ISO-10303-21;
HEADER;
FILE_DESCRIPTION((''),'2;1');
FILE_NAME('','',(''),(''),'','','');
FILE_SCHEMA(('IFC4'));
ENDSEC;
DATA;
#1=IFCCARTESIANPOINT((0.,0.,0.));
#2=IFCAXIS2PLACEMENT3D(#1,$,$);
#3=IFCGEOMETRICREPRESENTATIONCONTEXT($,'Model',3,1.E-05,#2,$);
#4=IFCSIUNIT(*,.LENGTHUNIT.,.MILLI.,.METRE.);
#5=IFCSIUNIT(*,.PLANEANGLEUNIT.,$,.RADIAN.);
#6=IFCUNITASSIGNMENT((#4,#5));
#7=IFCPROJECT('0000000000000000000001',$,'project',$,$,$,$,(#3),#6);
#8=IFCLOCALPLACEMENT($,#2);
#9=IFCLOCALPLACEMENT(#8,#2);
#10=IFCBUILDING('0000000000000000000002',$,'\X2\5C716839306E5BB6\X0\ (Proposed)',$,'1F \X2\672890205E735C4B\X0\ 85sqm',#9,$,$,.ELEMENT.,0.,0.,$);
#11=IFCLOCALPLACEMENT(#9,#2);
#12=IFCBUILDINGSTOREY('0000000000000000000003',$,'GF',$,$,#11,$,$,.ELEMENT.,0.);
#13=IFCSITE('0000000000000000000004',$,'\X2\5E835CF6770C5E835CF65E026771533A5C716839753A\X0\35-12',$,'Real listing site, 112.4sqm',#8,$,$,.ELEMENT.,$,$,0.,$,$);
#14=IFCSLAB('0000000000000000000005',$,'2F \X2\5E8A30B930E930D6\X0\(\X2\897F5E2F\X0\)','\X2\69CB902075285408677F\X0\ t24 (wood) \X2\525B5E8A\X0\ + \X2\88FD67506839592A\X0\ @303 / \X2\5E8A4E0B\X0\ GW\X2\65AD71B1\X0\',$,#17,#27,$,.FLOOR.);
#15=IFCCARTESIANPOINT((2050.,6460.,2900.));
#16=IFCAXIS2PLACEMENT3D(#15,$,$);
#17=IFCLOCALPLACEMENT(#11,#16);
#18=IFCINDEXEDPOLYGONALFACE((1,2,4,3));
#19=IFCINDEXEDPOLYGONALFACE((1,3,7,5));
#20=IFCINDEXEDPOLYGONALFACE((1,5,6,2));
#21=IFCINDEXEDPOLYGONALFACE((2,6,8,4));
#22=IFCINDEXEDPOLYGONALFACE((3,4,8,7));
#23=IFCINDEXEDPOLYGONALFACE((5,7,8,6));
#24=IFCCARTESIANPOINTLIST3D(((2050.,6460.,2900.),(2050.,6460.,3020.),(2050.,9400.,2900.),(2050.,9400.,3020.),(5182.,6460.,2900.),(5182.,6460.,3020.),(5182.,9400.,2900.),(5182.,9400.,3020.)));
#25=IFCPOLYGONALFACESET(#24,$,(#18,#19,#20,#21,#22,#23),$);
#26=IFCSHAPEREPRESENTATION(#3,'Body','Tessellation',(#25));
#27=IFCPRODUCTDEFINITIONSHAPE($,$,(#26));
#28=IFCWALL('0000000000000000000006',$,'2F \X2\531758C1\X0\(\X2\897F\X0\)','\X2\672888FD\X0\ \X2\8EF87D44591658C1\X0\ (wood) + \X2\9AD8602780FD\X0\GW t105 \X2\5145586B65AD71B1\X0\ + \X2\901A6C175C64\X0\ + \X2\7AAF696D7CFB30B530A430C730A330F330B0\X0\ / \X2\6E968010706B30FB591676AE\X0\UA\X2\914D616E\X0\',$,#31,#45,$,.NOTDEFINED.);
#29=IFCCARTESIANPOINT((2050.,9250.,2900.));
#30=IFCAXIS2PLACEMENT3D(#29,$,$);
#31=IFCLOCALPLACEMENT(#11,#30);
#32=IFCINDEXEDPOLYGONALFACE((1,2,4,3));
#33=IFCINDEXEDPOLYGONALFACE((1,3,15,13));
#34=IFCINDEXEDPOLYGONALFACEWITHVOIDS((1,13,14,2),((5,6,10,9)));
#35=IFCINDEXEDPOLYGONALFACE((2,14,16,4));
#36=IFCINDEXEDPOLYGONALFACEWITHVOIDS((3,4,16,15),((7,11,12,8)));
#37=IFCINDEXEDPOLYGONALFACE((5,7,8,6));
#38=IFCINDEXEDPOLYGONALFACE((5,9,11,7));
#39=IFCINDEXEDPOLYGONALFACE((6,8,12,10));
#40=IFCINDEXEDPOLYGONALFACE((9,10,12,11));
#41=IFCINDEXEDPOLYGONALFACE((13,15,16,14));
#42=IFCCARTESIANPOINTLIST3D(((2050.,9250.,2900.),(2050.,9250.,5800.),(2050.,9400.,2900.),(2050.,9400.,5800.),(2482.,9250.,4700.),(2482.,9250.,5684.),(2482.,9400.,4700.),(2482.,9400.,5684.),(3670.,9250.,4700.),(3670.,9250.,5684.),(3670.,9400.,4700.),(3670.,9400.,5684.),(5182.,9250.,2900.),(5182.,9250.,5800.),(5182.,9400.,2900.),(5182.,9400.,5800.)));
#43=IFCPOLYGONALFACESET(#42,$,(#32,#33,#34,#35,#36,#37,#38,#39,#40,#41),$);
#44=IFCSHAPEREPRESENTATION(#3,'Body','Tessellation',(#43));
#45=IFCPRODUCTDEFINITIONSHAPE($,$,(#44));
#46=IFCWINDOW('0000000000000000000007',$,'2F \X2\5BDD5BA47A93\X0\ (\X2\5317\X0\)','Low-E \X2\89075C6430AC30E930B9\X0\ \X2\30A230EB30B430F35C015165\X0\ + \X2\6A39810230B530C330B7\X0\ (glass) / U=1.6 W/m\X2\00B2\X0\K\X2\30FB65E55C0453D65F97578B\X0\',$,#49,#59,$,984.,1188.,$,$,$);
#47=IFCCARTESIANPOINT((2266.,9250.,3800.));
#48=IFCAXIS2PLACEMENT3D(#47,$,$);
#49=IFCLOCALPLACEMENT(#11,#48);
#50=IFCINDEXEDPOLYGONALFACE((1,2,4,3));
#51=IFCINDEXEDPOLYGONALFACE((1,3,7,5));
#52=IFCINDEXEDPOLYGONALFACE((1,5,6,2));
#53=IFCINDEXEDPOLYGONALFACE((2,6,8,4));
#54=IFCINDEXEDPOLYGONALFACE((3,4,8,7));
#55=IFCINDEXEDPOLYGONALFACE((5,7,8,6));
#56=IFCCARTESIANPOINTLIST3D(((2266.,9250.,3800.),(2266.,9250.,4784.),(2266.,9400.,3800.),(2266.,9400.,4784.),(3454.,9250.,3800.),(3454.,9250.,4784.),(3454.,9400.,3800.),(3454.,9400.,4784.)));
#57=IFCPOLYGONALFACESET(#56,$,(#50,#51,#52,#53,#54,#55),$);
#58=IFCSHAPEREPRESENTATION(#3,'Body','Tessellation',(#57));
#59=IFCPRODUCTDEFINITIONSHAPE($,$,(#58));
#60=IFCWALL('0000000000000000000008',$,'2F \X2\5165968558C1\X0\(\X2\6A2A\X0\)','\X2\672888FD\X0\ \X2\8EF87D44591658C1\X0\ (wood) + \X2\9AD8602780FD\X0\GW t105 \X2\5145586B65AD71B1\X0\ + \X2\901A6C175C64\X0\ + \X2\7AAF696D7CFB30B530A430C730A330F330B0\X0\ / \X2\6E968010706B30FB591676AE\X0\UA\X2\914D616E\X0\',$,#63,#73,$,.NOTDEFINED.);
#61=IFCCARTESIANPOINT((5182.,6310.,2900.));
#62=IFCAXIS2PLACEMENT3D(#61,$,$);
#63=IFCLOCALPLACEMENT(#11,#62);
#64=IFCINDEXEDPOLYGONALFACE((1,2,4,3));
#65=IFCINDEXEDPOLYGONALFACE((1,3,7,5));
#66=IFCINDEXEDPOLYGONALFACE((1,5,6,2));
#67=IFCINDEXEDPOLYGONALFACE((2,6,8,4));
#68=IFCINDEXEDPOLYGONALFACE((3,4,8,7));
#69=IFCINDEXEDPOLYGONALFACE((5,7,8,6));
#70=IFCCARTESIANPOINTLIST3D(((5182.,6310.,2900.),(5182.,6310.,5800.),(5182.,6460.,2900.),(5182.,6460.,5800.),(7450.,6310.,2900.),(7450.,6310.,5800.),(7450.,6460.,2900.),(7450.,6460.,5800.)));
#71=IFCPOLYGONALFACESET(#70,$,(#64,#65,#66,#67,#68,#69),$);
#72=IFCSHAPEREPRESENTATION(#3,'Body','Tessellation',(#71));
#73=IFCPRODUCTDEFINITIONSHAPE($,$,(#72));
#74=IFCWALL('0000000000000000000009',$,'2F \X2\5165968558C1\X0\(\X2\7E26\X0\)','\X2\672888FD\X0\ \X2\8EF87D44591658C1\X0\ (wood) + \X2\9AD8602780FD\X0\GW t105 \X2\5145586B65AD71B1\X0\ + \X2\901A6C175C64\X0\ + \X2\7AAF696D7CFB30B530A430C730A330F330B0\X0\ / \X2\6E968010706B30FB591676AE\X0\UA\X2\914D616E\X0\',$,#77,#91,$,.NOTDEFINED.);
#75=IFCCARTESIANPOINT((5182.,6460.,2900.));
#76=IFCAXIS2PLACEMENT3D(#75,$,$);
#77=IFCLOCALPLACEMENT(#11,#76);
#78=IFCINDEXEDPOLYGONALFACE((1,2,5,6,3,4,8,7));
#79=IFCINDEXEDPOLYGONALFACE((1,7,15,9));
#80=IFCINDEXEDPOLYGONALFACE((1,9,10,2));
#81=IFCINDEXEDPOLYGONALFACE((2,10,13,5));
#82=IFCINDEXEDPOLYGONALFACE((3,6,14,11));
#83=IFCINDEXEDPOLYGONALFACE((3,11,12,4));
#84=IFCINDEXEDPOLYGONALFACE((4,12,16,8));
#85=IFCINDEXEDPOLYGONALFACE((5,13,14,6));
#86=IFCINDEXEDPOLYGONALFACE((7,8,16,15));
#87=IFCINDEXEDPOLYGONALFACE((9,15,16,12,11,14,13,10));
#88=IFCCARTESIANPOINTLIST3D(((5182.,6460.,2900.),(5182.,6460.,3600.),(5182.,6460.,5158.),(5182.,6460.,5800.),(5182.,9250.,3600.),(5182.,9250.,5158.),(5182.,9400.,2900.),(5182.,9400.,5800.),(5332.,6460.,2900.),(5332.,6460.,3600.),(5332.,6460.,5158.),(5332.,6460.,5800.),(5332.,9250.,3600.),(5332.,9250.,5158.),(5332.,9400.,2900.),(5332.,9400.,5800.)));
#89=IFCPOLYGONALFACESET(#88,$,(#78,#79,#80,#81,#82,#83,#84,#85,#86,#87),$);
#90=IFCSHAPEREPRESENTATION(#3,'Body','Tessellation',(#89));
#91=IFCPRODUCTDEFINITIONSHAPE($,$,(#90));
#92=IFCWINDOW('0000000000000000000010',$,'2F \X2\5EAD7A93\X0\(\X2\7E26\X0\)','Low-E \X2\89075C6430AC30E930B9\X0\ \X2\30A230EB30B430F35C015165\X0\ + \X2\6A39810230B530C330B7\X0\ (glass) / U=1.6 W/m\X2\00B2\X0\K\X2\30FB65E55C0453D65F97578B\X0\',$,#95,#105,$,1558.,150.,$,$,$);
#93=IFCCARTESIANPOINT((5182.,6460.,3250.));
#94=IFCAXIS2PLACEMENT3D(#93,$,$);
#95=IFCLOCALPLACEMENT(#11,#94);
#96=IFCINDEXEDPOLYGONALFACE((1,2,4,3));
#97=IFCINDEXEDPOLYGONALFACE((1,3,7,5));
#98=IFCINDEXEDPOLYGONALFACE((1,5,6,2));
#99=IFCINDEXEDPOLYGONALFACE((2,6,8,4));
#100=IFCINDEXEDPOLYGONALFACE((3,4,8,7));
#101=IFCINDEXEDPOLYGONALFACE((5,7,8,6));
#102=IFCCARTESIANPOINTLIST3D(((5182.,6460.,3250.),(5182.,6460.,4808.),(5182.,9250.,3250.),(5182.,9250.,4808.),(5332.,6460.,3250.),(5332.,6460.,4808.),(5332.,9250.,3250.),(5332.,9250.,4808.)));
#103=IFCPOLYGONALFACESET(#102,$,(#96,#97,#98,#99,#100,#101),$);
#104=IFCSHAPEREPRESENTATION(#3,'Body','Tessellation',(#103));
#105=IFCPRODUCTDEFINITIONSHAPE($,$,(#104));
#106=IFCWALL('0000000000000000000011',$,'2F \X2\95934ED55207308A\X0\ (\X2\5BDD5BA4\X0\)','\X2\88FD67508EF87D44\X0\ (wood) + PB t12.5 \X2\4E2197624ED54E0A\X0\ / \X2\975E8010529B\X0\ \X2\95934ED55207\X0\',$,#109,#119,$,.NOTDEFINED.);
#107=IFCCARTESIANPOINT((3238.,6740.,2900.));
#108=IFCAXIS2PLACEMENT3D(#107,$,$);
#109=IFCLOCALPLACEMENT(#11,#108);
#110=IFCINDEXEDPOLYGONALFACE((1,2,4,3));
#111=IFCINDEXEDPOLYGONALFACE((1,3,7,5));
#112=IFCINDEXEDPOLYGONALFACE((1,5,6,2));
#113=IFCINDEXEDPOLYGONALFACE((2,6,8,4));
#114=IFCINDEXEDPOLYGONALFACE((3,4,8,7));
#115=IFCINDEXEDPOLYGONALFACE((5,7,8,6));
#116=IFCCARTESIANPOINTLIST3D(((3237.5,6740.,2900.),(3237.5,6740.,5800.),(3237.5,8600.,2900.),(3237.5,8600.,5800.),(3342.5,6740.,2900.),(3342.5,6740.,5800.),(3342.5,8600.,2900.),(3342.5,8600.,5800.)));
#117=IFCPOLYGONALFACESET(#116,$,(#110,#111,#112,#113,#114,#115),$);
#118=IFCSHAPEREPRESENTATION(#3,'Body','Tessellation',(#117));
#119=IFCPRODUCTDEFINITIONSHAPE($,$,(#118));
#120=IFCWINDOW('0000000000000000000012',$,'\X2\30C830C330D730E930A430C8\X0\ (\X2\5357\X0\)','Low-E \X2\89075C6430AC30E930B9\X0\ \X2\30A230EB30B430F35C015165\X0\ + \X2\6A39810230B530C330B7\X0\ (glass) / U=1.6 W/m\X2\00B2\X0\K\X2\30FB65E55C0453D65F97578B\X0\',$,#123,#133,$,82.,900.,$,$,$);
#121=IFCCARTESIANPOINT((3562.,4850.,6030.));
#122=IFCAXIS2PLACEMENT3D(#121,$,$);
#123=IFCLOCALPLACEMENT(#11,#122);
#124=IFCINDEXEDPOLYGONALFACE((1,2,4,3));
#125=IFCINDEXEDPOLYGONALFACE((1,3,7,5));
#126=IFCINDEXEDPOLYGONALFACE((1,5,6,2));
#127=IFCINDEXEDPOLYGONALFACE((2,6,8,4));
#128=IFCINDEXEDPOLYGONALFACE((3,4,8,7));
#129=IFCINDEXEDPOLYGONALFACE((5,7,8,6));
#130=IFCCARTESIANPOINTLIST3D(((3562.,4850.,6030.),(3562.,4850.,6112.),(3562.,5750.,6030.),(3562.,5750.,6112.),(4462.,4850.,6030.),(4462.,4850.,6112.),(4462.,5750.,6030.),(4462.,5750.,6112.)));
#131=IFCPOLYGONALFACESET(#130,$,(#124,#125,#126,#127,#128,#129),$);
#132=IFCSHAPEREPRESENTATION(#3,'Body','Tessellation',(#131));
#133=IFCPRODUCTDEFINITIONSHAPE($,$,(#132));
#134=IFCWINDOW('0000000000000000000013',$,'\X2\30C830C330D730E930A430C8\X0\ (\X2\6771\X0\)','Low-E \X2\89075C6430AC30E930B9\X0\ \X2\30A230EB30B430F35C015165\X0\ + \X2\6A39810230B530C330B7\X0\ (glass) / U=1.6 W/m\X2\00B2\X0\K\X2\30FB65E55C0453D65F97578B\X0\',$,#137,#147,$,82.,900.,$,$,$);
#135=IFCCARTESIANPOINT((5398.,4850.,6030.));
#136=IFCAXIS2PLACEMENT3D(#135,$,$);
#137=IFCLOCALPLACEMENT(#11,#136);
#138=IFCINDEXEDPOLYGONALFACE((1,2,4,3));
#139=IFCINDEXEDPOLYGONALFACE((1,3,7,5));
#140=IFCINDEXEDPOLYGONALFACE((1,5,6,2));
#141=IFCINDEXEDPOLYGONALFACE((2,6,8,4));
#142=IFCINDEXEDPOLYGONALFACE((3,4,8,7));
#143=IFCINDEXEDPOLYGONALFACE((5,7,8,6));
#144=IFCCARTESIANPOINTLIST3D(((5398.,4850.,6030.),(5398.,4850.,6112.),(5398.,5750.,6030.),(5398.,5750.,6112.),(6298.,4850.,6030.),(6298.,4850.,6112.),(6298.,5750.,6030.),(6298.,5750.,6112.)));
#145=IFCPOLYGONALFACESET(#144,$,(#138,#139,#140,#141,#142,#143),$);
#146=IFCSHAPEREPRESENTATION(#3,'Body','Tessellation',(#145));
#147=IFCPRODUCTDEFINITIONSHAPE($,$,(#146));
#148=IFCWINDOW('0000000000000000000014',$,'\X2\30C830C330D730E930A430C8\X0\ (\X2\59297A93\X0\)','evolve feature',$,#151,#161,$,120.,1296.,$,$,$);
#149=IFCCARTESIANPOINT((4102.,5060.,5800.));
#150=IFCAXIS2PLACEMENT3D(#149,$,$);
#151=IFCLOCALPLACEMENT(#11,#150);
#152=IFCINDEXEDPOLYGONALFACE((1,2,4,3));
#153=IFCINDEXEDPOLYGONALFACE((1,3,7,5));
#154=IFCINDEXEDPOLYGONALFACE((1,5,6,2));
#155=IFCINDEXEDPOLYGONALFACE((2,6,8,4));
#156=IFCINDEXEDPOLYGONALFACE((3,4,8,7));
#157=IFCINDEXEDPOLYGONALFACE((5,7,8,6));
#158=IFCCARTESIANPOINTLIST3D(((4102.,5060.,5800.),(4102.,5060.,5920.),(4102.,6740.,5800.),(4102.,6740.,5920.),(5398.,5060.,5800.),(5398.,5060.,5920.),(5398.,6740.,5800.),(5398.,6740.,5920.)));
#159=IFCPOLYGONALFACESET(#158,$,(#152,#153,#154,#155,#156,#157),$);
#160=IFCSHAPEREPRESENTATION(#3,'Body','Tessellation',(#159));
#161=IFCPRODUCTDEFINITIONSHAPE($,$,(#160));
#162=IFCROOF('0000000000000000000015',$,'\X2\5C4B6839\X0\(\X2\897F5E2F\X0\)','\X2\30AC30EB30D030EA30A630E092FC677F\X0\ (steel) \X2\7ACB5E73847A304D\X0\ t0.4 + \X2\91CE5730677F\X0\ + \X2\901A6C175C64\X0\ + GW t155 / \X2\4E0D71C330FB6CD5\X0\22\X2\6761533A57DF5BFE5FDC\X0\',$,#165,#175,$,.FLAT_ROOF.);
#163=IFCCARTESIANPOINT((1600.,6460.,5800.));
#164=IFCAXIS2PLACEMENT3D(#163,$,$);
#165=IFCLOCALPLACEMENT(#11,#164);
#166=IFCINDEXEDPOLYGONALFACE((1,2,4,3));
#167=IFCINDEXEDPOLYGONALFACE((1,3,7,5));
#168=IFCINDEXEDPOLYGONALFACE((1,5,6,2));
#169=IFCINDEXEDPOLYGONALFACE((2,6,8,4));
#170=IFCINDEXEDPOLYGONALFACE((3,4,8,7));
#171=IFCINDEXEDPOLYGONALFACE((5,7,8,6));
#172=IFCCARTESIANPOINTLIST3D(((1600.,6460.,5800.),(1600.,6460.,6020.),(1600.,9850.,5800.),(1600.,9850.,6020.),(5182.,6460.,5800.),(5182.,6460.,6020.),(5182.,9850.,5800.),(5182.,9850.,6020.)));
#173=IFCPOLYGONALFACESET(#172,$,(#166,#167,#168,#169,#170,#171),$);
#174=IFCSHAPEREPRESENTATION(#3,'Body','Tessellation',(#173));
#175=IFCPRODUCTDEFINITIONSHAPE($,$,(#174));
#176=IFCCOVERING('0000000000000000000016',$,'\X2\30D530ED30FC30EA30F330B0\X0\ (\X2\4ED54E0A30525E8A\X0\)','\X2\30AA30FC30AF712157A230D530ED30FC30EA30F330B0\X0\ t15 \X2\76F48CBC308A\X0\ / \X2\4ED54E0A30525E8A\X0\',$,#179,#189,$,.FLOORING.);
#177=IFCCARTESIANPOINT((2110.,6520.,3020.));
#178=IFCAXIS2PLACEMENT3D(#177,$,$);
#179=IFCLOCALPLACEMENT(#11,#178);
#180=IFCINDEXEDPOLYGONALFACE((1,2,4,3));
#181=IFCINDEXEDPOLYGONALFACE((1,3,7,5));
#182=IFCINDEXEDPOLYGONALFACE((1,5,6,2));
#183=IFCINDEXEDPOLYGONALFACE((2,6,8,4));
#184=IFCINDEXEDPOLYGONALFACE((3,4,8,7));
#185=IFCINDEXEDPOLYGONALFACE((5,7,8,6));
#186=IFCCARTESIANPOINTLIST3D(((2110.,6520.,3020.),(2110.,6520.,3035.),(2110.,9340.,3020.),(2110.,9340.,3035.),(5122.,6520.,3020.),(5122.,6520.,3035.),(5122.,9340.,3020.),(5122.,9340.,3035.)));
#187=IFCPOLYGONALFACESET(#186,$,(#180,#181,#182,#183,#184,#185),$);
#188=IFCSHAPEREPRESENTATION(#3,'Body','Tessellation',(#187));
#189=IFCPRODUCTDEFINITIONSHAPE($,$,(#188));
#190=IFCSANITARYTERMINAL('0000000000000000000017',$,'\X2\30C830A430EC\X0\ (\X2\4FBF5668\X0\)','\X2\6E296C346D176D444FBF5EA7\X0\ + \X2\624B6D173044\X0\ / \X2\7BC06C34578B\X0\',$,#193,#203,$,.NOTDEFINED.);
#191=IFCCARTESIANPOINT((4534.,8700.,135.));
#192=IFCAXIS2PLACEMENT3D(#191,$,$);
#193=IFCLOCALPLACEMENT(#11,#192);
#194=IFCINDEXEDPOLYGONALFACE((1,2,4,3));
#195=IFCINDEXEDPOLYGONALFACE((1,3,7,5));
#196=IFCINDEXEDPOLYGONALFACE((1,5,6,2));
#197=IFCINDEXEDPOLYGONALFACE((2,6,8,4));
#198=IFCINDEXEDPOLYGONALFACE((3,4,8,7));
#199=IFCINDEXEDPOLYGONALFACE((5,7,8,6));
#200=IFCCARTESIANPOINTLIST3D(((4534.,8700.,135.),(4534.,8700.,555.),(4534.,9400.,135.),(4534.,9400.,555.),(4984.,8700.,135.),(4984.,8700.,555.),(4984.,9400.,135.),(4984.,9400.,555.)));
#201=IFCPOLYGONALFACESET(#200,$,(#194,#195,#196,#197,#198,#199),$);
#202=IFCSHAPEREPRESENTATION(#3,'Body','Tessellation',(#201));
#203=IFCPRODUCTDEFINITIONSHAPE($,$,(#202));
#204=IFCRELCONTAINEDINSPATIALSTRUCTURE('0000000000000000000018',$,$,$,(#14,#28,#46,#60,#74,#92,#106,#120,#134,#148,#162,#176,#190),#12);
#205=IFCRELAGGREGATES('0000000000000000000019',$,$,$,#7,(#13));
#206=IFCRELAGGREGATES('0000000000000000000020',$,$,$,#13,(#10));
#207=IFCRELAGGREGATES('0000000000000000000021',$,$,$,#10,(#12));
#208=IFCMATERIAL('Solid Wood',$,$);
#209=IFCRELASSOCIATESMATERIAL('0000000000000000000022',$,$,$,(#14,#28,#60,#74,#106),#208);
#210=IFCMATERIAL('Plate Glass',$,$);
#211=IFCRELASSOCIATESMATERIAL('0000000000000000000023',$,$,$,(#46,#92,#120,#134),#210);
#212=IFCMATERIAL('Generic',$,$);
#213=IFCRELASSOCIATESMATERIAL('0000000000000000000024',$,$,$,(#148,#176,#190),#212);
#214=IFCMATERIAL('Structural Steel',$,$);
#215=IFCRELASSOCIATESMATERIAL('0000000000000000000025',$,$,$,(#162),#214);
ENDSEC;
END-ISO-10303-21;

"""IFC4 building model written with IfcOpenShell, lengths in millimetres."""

from ifc_helpers import new_model, si_unit, frame, frame_2d, origin, place, context, project, spatial, rectangle, extrude, material, element, fill, save


model = new_model("IFC4")

# Units and contexts
model_context = context("Model", 3, precision=1e-05, world=origin())
ifc_project = project(units=[si_unit("LENGTHUNIT", "METRE", prefix="MILLI"), si_unit("PLANEANGLEUNIT", "RADIAN")], contexts=[model_context])

# Site, building, storey
site_placement = place(None, origin())
site = spatial("IfcSite", under=ifc_project, at=site_placement, Name="広島県広島市東区山根町35-12", ObjectType="Real listing site, 112.4sqm", CompositionType="ELEMENT", RefElevation=0.0)
building_placement = place(site_placement, origin())
building = spatial("IfcBuilding", under=site, at=building_placement, Name="山根の家 (Proposed)", ObjectType="1F 木造平屋 85sqm", CompositionType="ELEMENT", ElevationOfRefHeight=0.0, ElevationOfTerrain=0.0)
storey_placement = place(building_placement, origin())
storey = spatial("IfcBuildingStorey", under=building, at=storey_placement, Name="GF", CompositionType="ELEMENT", Elevation=0.0)

# Slab
ifc_material_1 = material(Name="Solid Wood")
slab_placement = place(storey_placement, frame((2050.0, 6460.0, 2900.0)))
element("IfcSlab", 1, at=slab_placement, inside=storey, material=ifc_material_1, Name="2F 床スラブ(西帯)", Description="構造用合板 t24 (wood) 剛床 + 製材根太 @303 / 床下 GW断熱", PredefinedType="FLOOR", context=model_context, shape_type="SweptSolid", body=[
    extrude(rectangle(XDim=3132.0, YDim=2940.0, at=frame_2d((1566.0, 1470.0))), frame((2050.0, 6460.0, 2900.0)), (0.0, 0.0, 1.0), 120.0),
])

# Wall, opening, window
wall_1_placement = place(storey_placement, frame((2050.0, 9250.0, 2900.0)))
wall_1 = element("IfcWall", 2, at=wall_1_placement, inside=storey, material=ifc_material_1, Name="2F 北壁(西)", Description="木製 軸組外壁 (wood) + 高性能GW t105 充填断熱 + 通気層 + 窯業系サイディング / 準耐火・外皮UA配慮", PredefinedType="NOTDEFINED", context=model_context, shape_type="SweptSolid", body=[
    extrude(rectangle(XDim=3132.0, YDim=150.0, at=frame_2d((1566.0, 75.0))), frame((2050.0, 9250.0, 2900.0)), (0.0, 0.0, 1.0), 2900.0),
])
opening_1_placement = place(storey_placement, frame((2266.0, 9250.0, 3800.0)))
opening_1 = element("IfcOpeningElement", 3, at=opening_1_placement, cuts=wall_1, PredefinedType="NOTDEFINED", context=model_context, shape_type="SweptSolid", body=[
    extrude(rectangle(XDim=1188.0, YDim=150.0, at=frame_2d((594.0, 75.0))), frame((2266.0, 9250.0, 3800.0)), (0.0, 0.0, 1.0), 984.0),
])
ifc_material_2 = material(Name="Plate Glass")
window_1_placement = place(storey_placement, frame((2266.0, 9250.0, 3800.0)))
window_1 = element("IfcWindow", 4, at=window_1_placement, inside=storey, material=ifc_material_2, Name="2F 寝室窓 (北)", Description="Low-E 複層ガラス アルゴン封入 + 樹脂サッシ (glass) / U=1.6 W/m²K・日射取得型", OverallHeight=984.0, OverallWidth=1188.0, context=model_context, shape_type="SweptSolid", body=[
    extrude(rectangle(XDim=1188.0, YDim=150.0, at=frame_2d((594.0, 75.0))), frame((2266.0, 9250.0, 3800.0)), (0.0, 0.0, 1.0), 984.0),
])
fill(opening_1, window_1)

# Wall
wall_2_placement = place(storey_placement, frame((5182.0, 6310.0, 2900.0)))
element("IfcWall", 5, at=wall_2_placement, inside=storey, material=ifc_material_1, Name="2F 入隅壁(横)", Description="木製 軸組外壁 (wood) + 高性能GW t105 充填断熱 + 通気層 + 窯業系サイディング / 準耐火・外皮UA配慮", PredefinedType="NOTDEFINED", context=model_context, shape_type="SweptSolid", body=[
    extrude(rectangle(XDim=2268.0, YDim=150.0, at=frame_2d((1134.0, 75.0))), frame((5182.0, 6310.0, 2900.0)), (0.0, 0.0, 1.0), 2900.0),
])

# Wall, opening, window
wall_3_placement = place(storey_placement, frame((5182.0, 6460.0, 2900.0)))
wall_3 = element("IfcWall", 6, at=wall_3_placement, inside=storey, material=ifc_material_1, Name="2F 入隅壁(縦)", Description="木製 軸組外壁 (wood) + 高性能GW t105 充填断熱 + 通気層 + 窯業系サイディング / 準耐火・外皮UA配慮", PredefinedType="NOTDEFINED", context=model_context, shape_type="SweptSolid", body=[
    extrude(rectangle(XDim=150.0, YDim=2940.0, at=frame_2d((75.0, 1470.0))), frame((5182.0, 6460.0, 2900.0)), (0.0, 0.0, 1.0), 2900.0),
])
opening_2_placement = place(storey_placement, frame((5182.0, 6460.0, 3250.0)))
opening_2 = element("IfcOpeningElement", 7, at=opening_2_placement, cuts=wall_3, PredefinedType="NOTDEFINED", context=model_context, shape_type="SweptSolid", body=[
    extrude(rectangle(XDim=150.0, YDim=2790.0, at=frame_2d((75.0, 1395.0))), frame((5182.0, 6460.0, 3250.0)), (0.0, 0.0, 1.0), 1558.0),
])
window_2_placement = place(storey_placement, frame((5182.0, 6460.0, 3250.0)))
window_2 = element("IfcWindow", 8, at=window_2_placement, inside=storey, material=ifc_material_2, Name="2F 庭窓(縦)", Description="Low-E 複層ガラス アルゴン封入 + 樹脂サッシ (glass) / U=1.6 W/m²K・日射取得型", OverallHeight=1558.0, OverallWidth=150.0, context=model_context, shape_type="SweptSolid", body=[
    extrude(rectangle(XDim=150.0, YDim=2790.0, at=frame_2d((75.0, 1395.0))), frame((5182.0, 6460.0, 3250.0)), (0.0, 0.0, 1.0), 1558.0),
])
fill(opening_2, window_2)

# Wall
wall_4_placement = place(storey_placement, frame((3238.0, 6740.0, 2900.0)))
element("IfcWall", 9, at=wall_4_placement, inside=storey, material=ifc_material_1, Name="2F 間仕切り (寝室)", Description="製材軸組 (wood) + PB t12.5 両面仕上 / 非耐力 間仕切", PredefinedType="NOTDEFINED", context=model_context, shape_type="SweptSolid", body=[
    extrude(rectangle(XDim=105.0, YDim=1860.0, at=frame_2d((52.0, 930.0))), frame((3238.0, 6740.0, 2900.0)), (0.0, 0.0, 1.0), 2900.0),
])

# Windows
window_3_placement = place(storey_placement, frame((3562.0, 4850.0, 6030.0)))
element("IfcWindow", 10, at=window_3_placement, inside=storey, material=ifc_material_2, Name="トップライト (南)", Description="Low-E 複層ガラス アルゴン封入 + 樹脂サッシ (glass) / U=1.6 W/m²K・日射取得型", OverallHeight=82.0, OverallWidth=900.0, context=model_context, shape_type="SweptSolid", body=[
    extrude(rectangle(XDim=900.0, YDim=900.0, at=frame_2d((450.0, 450.0))), frame((3562.0, 4850.0, 6030.0)), (0.0, 0.0, 1.0), 82.0),
])
window_4_placement = place(storey_placement, frame((5398.0, 4850.0, 6030.0)))
element("IfcWindow", 11, at=window_4_placement, inside=storey, material=ifc_material_2, Name="トップライト (東)", Description="Low-E 複層ガラス アルゴン封入 + 樹脂サッシ (glass) / U=1.6 W/m²K・日射取得型", OverallHeight=82.0, OverallWidth=900.0, context=model_context, shape_type="SweptSolid", body=[
    extrude(rectangle(XDim=900.0, YDim=900.0, at=frame_2d((450.0, 450.0))), frame((5398.0, 4850.0, 6030.0)), (0.0, 0.0, 1.0), 82.0),
])
ifc_material_3 = material(Name="Generic")
window_5_placement = place(storey_placement, frame((4102.0, 5060.0, 5800.0)))
element("IfcWindow", 12, at=window_5_placement, inside=storey, material=ifc_material_3, Name="トップライト (天窓)", Description="evolve feature", OverallHeight=120.0, OverallWidth=1296.0, context=model_context, shape_type="SweptSolid", body=[
    extrude(rectangle(XDim=1296.0, YDim=1680.0, at=frame_2d((648.0, 840.0))), frame((4102.0, 5060.0, 5800.0)), (0.0, 0.0, 1.0), 120.0),
])

# Roof
ifc_material_4 = material(Name="Structural Steel")
for number, where, name in (
    (13, (1600.0, 6460.0, 5800.0), "屋根(西帯)"),
):
    element("IfcRoof", number, at=place(storey_placement, frame(where)), inside=storey, material=ifc_material_4, Name=name, Description="ガルバリウム鋼板 (steel) 立平葺き t0.4 + 野地板 + 通気層 + GW t155 / 不燃・法22条区域対応", PredefinedType="FLAT_ROOF", context=model_context, shape_type="SweptSolid", body=[
        extrude(rectangle(XDim=3582.0, YDim=3390.0, at=frame_2d((1791.0, 1695.0))), frame((1600.0, 6460.0, 5800.0)), (0.0, 0.0, 1.0), 220.0),
    ])

# Covering
covering_placement = place(storey_placement, frame((2110.0, 6520.0, 3020.0)))
element("IfcCovering", 14, at=covering_placement, inside=storey, material=ifc_material_3, Name="フローリング (仕上げ床)", Description="オーク無垢フローリング t15 直貼り / 仕上げ床", PredefinedType="FLOORING", context=model_context, shape_type="SweptSolid", body=[
    extrude(rectangle(XDim=3012.0, YDim=2820.0, at=frame_2d((1506.0, 1410.0))), frame((2110.0, 6520.0, 3020.0)), (0.0, 0.0, 1.0), 15.0),
])

# Sanitary terminal
sanitary_terminal_placement = place(storey_placement, frame((4534.0, 8700.0, 135.0)))
element("IfcSanitaryTerminal", 15, at=sanitary_terminal_placement, inside=storey, material=ifc_material_3, Name="トイレ (便器)", Description="温水洗浄便座 + 手洗い / 節水型", PredefinedType="NOTDEFINED", context=model_context, shape_type="SweptSolid", body=[
    extrude(rectangle(XDim=450.0, YDim=700.0, at=frame_2d((225.0, 350.0))), frame((4534.0, 8700.0, 135.0)), (0.0, 0.0, 1.0), 420.0),
])

save(model, "model.ifc")
